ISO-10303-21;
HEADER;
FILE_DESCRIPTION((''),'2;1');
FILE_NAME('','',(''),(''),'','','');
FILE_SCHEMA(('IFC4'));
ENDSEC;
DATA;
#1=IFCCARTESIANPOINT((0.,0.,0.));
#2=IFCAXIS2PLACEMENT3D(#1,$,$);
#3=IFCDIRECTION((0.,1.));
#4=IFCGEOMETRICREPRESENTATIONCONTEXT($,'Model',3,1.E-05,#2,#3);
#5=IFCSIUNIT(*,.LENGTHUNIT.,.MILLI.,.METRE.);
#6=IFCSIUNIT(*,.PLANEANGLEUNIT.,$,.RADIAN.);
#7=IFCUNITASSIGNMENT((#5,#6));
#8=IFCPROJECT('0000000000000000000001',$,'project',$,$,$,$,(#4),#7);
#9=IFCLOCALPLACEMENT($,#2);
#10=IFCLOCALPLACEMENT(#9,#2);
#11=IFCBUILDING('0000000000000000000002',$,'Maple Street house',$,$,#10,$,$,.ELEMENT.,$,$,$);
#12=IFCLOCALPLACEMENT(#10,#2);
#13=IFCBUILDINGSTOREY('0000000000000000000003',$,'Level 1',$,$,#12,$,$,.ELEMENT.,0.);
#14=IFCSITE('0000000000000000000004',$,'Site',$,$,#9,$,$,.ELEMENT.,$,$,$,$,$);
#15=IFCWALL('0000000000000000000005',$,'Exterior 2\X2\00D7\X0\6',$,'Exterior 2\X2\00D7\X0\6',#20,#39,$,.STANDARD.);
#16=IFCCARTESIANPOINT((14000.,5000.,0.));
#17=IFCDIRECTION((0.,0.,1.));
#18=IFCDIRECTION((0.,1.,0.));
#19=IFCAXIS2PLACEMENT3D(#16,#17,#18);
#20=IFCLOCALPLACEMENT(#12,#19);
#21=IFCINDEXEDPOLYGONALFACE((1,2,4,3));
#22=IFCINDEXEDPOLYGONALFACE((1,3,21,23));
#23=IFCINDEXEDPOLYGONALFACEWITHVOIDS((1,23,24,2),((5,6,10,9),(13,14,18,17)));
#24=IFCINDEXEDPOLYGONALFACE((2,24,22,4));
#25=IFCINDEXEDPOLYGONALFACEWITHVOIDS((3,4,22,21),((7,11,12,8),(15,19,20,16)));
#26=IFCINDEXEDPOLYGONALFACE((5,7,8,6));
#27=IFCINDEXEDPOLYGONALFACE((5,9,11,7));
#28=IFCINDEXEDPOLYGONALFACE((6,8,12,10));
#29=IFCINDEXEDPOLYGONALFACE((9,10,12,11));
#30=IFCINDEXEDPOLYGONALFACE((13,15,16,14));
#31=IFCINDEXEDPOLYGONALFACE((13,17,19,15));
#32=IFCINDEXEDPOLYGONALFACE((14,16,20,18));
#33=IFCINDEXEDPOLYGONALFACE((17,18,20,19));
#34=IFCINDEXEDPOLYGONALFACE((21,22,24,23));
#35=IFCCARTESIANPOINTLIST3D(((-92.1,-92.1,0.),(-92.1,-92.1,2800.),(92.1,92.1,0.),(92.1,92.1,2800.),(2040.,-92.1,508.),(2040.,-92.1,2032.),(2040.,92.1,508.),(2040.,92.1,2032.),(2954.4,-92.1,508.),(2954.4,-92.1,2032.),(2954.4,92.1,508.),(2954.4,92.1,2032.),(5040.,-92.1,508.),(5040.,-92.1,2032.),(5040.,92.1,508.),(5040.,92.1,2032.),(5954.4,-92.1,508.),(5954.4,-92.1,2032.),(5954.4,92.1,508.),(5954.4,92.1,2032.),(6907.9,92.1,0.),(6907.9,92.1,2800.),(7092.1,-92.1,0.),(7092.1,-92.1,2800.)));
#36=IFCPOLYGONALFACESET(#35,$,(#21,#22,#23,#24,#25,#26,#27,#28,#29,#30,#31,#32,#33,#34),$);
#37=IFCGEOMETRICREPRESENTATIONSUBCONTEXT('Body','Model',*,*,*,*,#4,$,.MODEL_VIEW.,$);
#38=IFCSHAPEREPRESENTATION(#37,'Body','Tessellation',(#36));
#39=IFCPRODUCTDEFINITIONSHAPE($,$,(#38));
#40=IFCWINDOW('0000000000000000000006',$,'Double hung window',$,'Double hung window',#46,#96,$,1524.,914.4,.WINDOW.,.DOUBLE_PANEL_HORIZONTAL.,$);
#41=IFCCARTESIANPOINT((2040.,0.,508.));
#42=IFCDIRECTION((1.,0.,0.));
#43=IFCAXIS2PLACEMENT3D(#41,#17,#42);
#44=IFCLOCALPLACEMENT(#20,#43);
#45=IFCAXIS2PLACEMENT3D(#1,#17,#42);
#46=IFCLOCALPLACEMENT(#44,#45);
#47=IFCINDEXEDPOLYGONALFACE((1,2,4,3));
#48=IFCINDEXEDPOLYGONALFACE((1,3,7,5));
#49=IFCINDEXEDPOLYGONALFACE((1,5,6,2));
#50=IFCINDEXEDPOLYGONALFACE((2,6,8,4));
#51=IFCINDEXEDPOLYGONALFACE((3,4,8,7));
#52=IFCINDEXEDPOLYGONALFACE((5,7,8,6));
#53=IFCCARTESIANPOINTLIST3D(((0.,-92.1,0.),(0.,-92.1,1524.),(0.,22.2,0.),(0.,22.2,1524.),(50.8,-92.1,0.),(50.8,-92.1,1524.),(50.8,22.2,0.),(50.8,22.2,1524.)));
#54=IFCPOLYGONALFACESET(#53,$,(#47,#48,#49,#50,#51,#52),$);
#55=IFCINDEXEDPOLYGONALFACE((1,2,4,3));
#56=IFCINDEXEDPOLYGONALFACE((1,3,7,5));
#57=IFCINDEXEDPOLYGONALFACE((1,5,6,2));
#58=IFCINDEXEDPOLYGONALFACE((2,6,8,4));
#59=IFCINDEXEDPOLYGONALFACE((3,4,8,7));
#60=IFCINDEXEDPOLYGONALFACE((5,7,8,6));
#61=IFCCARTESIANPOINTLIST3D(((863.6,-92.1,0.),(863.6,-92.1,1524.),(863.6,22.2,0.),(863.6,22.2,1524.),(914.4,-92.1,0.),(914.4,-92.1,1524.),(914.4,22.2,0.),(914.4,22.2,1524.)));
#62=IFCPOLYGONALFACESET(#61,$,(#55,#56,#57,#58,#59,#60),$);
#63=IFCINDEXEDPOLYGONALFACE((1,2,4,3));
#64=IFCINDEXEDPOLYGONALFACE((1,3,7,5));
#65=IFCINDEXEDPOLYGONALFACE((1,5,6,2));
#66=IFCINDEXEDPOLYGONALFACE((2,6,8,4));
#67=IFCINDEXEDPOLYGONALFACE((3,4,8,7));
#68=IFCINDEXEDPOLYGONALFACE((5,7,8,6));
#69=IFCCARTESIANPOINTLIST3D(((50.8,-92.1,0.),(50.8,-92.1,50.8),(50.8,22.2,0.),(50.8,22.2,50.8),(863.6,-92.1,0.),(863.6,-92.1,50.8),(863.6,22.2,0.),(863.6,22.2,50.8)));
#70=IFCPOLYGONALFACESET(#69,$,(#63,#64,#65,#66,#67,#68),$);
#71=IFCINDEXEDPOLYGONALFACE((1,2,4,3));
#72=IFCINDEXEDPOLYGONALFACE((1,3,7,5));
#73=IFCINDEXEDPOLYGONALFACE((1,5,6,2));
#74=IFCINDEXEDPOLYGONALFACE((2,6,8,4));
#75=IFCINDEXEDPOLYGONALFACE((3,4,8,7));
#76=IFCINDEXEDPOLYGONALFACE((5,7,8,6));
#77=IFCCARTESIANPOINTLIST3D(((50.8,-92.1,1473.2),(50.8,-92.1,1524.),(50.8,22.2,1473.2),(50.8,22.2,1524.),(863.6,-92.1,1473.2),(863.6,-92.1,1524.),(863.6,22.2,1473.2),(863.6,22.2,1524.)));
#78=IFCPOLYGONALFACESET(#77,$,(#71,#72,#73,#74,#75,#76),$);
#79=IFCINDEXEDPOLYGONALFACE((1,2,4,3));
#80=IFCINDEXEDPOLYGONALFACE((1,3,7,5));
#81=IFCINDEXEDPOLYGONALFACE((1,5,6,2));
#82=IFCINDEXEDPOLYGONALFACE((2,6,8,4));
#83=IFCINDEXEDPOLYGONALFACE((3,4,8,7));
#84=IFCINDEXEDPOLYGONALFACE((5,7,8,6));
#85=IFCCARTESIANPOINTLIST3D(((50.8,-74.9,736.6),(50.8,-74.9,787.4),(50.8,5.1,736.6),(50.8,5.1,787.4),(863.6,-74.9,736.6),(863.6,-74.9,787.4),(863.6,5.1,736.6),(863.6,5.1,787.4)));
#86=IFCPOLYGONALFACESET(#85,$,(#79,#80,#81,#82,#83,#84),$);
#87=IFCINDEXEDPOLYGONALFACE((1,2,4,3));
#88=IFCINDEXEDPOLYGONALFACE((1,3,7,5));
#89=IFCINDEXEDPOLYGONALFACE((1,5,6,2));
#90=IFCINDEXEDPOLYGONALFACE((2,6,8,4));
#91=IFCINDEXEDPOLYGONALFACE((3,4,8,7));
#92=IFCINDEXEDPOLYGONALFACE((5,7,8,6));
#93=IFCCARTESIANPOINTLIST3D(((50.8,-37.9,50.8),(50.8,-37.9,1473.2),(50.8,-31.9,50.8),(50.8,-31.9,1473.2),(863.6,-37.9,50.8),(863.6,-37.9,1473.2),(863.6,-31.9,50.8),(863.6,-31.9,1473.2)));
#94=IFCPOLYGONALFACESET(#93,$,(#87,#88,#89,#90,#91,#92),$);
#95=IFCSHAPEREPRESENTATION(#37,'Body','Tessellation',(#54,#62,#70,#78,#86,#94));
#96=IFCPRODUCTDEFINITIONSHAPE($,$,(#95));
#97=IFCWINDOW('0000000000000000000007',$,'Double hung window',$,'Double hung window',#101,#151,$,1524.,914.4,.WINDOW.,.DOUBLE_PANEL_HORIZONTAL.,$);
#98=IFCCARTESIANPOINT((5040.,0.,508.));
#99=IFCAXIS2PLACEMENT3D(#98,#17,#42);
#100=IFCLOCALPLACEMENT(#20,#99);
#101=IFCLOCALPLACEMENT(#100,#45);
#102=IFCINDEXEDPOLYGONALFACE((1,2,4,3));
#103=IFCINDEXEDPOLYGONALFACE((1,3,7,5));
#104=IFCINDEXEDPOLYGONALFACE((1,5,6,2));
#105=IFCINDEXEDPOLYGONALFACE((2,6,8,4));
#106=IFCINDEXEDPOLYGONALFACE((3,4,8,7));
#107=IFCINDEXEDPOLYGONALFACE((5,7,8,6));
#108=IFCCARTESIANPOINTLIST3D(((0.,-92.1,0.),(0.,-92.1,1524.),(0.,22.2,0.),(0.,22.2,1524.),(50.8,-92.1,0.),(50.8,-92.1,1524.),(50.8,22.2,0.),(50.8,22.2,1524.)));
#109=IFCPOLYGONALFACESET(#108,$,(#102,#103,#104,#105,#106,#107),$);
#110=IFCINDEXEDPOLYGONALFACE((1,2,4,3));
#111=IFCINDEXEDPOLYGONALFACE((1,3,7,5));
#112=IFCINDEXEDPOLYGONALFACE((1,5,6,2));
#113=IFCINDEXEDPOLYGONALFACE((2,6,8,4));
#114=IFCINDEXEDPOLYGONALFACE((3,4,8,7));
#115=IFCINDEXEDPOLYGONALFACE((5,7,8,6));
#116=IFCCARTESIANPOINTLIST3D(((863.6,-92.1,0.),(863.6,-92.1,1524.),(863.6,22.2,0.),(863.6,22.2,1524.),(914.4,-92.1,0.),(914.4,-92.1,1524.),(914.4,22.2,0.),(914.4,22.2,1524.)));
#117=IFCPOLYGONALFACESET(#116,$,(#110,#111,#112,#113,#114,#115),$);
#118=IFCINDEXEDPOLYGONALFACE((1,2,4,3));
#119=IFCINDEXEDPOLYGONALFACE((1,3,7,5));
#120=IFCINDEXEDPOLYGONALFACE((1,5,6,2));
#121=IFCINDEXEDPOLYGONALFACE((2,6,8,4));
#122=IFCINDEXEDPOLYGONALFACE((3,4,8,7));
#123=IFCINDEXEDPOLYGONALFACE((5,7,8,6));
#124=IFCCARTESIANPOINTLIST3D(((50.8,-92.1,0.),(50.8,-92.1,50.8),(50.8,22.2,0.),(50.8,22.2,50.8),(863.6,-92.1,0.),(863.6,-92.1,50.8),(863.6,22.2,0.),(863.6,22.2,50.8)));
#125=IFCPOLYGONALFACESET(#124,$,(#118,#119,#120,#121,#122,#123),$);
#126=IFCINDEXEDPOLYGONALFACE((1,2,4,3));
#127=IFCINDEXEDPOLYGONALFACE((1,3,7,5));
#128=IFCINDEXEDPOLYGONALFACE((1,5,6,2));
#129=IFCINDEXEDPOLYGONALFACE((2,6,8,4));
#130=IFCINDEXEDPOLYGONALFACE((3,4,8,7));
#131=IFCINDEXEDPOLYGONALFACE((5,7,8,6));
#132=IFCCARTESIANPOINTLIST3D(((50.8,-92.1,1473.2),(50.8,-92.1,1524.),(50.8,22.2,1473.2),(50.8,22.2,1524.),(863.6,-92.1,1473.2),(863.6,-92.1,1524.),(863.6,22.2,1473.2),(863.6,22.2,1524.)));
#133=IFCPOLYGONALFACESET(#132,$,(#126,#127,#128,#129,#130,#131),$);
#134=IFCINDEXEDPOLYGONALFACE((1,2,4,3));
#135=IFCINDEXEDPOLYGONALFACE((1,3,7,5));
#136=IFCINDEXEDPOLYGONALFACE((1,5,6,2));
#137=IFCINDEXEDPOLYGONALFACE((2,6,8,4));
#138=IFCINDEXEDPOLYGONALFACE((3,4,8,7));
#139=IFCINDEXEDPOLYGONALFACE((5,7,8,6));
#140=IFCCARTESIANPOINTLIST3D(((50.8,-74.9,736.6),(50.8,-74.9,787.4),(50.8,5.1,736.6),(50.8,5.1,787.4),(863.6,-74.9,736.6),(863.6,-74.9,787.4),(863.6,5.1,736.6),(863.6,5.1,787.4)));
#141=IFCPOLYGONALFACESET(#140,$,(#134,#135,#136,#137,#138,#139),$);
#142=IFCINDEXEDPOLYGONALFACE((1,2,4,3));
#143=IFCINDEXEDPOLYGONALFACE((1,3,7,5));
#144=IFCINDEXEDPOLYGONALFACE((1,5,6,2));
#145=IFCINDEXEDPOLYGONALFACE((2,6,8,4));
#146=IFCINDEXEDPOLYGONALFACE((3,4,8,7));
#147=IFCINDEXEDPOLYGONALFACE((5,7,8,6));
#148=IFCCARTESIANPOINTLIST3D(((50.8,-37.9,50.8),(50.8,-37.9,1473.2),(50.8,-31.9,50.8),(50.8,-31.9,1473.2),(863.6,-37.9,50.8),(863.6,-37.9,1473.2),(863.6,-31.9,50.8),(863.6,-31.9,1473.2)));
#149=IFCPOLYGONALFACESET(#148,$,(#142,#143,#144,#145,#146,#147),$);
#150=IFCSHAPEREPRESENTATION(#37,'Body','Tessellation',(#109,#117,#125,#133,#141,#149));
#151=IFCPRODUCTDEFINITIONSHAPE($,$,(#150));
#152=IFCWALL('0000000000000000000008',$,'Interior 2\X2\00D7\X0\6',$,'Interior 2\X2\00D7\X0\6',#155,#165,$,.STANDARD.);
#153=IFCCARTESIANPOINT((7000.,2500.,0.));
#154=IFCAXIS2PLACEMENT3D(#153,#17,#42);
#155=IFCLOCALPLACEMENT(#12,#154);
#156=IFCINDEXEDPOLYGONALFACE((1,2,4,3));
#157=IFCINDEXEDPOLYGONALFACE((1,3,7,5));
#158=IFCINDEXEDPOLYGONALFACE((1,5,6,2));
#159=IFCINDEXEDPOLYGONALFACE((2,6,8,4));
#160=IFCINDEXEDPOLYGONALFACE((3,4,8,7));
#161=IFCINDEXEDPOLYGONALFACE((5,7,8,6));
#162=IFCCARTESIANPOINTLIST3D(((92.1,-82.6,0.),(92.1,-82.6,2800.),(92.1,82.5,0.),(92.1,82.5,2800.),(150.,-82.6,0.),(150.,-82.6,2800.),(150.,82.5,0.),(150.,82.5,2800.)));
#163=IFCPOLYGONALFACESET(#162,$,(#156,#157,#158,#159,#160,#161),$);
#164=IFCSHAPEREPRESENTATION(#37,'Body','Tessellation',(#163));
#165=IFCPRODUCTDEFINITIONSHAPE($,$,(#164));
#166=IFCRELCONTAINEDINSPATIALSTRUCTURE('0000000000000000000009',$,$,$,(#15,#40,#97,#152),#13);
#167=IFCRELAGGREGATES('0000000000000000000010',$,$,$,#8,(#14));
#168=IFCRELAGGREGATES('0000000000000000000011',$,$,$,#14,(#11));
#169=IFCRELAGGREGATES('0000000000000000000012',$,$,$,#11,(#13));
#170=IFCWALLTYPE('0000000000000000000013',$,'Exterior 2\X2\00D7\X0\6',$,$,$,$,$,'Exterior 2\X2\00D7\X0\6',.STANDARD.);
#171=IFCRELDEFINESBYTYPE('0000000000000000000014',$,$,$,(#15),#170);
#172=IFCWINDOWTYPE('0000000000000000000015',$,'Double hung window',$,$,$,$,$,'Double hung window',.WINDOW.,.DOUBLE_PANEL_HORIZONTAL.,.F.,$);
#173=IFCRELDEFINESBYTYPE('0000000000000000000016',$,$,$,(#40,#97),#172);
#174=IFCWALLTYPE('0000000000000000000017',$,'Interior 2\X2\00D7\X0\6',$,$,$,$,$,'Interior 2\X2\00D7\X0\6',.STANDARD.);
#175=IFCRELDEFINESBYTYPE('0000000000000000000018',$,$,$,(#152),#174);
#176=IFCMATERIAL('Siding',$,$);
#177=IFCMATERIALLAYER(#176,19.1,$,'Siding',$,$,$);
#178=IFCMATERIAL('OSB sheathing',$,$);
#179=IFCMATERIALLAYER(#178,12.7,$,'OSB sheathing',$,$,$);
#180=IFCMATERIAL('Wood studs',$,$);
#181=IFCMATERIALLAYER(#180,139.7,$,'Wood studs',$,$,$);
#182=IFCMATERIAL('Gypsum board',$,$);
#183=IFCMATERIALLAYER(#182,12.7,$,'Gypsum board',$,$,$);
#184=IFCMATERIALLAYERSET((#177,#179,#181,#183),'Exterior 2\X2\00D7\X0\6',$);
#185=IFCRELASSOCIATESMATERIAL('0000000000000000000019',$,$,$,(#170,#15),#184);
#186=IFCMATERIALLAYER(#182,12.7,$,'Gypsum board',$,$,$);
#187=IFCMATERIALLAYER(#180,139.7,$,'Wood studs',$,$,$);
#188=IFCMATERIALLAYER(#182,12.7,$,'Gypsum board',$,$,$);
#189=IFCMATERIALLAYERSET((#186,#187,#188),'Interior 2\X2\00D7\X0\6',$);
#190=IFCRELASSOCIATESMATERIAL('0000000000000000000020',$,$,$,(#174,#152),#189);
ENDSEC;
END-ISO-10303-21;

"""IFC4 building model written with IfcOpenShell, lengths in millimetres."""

from ifc_helpers import new_model, si_unit, direction, frame, origin, origin_with_axes, place, context, subcontext, project, spatial, polyline, outline, extrude, material, layer, layer_set, layer_usage, type_object, element, fill, save


model = new_model("IFC4")

# Units and contexts
model_context = context("Model", 3, precision=1e-05, world=origin(), true_north=direction((0.0, 1.0)))
body_context = subcontext(model_context, "Body", "Model", "MODEL_VIEW")
ifc_project = project(units=[si_unit("LENGTHUNIT", "METRE", prefix="MILLI"), si_unit("PLANEANGLEUNIT", "RADIAN")], contexts=[model_context])

# Site, building, storey
site_placement = place(None, origin())
site = spatial("IfcSite", under=ifc_project, at=site_placement, Name="Site", CompositionType="ELEMENT")
building_placement = place(site_placement, origin())
building = spatial("IfcBuilding", under=site, at=building_placement, Name="Maple Street house", CompositionType="ELEMENT")
storey_placement = place(building_placement, origin())
storey = spatial("IfcBuildingStorey", under=building, at=storey_placement, Name="Level 1", CompositionType="ELEMENT", Elevation=0.0)

# Wall, openings, windows
ifc_material_1 = material(Name="Siding")
ifc_layer_1 = layer(ifc_material_1, 19.1, Name="Siding")
ifc_material_2 = material(Name="OSB sheathing")
ifc_layer_2 = layer(ifc_material_2, 12.7, Name="OSB sheathing")
ifc_material_3 = material(Name="Wood studs")
ifc_layer_3 = layer(ifc_material_3, 139.7, Name="Wood studs")
ifc_material_4 = material(Name="Gypsum board")
ifc_layer_4 = layer(ifc_material_4, 12.7, Name="Gypsum board")
ifc_layer_set_1 = layer_set([ifc_layer_1, ifc_layer_2, ifc_layer_3, ifc_layer_4], Name="Exterior 2×6")
ifc_layer_usage_1 = layer_usage(ifc_layer_set_1, "AXIS2", "POSITIVE", -92.1)
wall_type_1 = type_object("IfcWallType", Name="Exterior 2×6", ElementType="Exterior 2×6", PredefinedType="STANDARD", material=ifc_layer_set_1)
wall_1_placement = place(storey_placement, frame((14000.0, 5000.0, 0.0), z_axis=(0.0, 0.0, 1.0), x_axis=(0.0, 1.0, 0.0)))
wall_1 = element("IfcWall", 1, at=wall_1_placement, inside=storey, type_object=wall_type_1, material=ifc_layer_usage_1, Name="Exterior 2×6", ObjectType="Exterior 2×6", PredefinedType="STANDARD", context=body_context, shape_type="SweptSolid", body=[
    extrude(outline(polyline([(-92.1, -92.1), (7092.1, -92.1), (6907.9, 92.1), (92.1, 92.1), (-92.1, -92.1)])), origin(), (0.0, 0.0, 1.0), 2800.0),
])
opening_1_placement = place(wall_1_placement, frame((2040.0, 0.0, 508.0), z_axis=(0.0, 0.0, 1.0), x_axis=(1.0, 0.0, 0.0)))
opening_1 = element("IfcOpeningElement", 2, at=opening_1_placement, cuts=wall_1, PredefinedType="OPENING", context=body_context, shape_type="SweptSolid", body=[
    extrude(outline(polyline([(0.0, -102.1), (914.4, -102.1), (914.4, 102.1), (0.0, 102.1), (0.0, -102.1)])), origin(), (0.0, 0.0, 1.0), 1524.0),
])
opening_2_placement = place(wall_1_placement, frame((5040.0, 0.0, 508.0), z_axis=(0.0, 0.0, 1.0), x_axis=(1.0, 0.0, 0.0)))
opening_2 = element("IfcOpeningElement", 3, at=opening_2_placement, cuts=wall_1, PredefinedType="OPENING", context=body_context, shape_type="SweptSolid", body=[
    extrude(outline(polyline([(0.0, -102.1), (914.4, -102.1), (914.4, 102.1), (0.0, 102.1), (0.0, -102.1)])), origin(), (0.0, 0.0, 1.0), 1524.0),
])
window_type = type_object("IfcWindowType", Name="Double hung window", ElementType="Double hung window", ParameterTakesPrecedence=False, PartitioningType="DOUBLE_PANEL_HORIZONTAL", PredefinedType="WINDOW")
window_1_placement = place(opening_1_placement, origin_with_axes())
window_1 = element("IfcWindow", 4, at=window_1_placement, inside=storey, type_object=window_type, Name="Double hung window", ObjectType="Double hung window", OverallHeight=1524.0, OverallWidth=914.4, PartitioningType="DOUBLE_PANEL_HORIZONTAL", PredefinedType="WINDOW", context=body_context, shape_type="SweptSolid", body=[
    extrude(outline(polyline([(0.0, -92.1), (50.8, -92.1), (50.8, 22.2), (0.0, 22.2), (0.0, -92.1)])), origin(), (0.0, 0.0, 1.0), 1524.0),
    extrude(outline(polyline([(863.6, -92.1), (914.4, -92.1), (914.4, 22.2), (863.6, 22.2), (863.6, -92.1)])), origin(), (0.0, 0.0, 1.0), 1524.0),
    extrude(outline(polyline([(50.8, -92.1), (863.6, -92.1), (863.6, 22.2), (50.8, 22.2), (50.8, -92.1)])), origin(), (0.0, 0.0, 1.0), 50.8),
    extrude(outline(polyline([(50.8, -92.1), (863.6, -92.1), (863.6, 22.2), (50.8, 22.2), (50.8, -92.1)])), frame((0.0, 0.0, 1473.2)), (0.0, 0.0, 1.0), 50.8),
    extrude(outline(polyline([(50.8, -74.9), (863.6, -74.9), (863.6, 5.1), (50.8, 5.1), (50.8, -74.9)])), frame((0.0, 0.0, 736.6)), (0.0, 0.0, 1.0), 50.8),
    extrude(outline(polyline([(50.8, -37.9), (863.6, -37.9), (863.6, -31.9), (50.8, -31.9), (50.8, -37.9)])), frame((0.0, 0.0, 50.8)), (0.0, 0.0, 1.0), 1422.4),
])
fill(opening_1, window_1)
window_2_placement = place(opening_2_placement, origin_with_axes())
window_2 = element("IfcWindow", 5, at=window_2_placement, inside=storey, type_object=window_type, Name="Double hung window", ObjectType="Double hung window", OverallHeight=1524.0, OverallWidth=914.4, PartitioningType="DOUBLE_PANEL_HORIZONTAL", PredefinedType="WINDOW", context=body_context, shape_type="SweptSolid", body=[
    extrude(outline(polyline([(0.0, -92.1), (50.8, -92.1), (50.8, 22.2), (0.0, 22.2), (0.0, -92.1)])), origin(), (0.0, 0.0, 1.0), 1524.0),
    extrude(outline(polyline([(863.6, -92.1), (914.4, -92.1), (914.4, 22.2), (863.6, 22.2), (863.6, -92.1)])), origin(), (0.0, 0.0, 1.0), 1524.0),
    extrude(outline(polyline([(50.8, -92.1), (863.6, -92.1), (863.6, 22.2), (50.8, 22.2), (50.8, -92.1)])), origin(), (0.0, 0.0, 1.0), 50.8),
    extrude(outline(polyline([(50.8, -92.1), (863.6, -92.1), (863.6, 22.2), (50.8, 22.2), (50.8, -92.1)])), frame((0.0, 0.0, 1473.2)), (0.0, 0.0, 1.0), 50.8),
    extrude(outline(polyline([(50.8, -74.9), (863.6, -74.9), (863.6, 5.1), (50.8, 5.1), (50.8, -74.9)])), frame((0.0, 0.0, 736.6)), (0.0, 0.0, 1.0), 50.8),
    extrude(outline(polyline([(50.8, -37.9), (863.6, -37.9), (863.6, -31.9), (50.8, -31.9), (50.8, -37.9)])), frame((0.0, 0.0, 50.8)), (0.0, 0.0, 1.0), 1422.4),
])
fill(opening_2, window_2)

# Wall
ifc_layer_5 = layer(ifc_material_4, 12.7, Name="Gypsum board")
ifc_layer_6 = layer(ifc_material_3, 139.7, Name="Wood studs")
ifc_layer_7 = layer(ifc_material_4, 12.7, Name="Gypsum board")
ifc_layer_set_2 = layer_set([ifc_layer_5, ifc_layer_6, ifc_layer_7], Name="Interior 2×6")
ifc_layer_usage_2 = layer_usage(ifc_layer_set_2, "AXIS2", "NEGATIVE", 82.5)
wall_type_2 = type_object("IfcWallType", Name="Interior 2×6", ElementType="Interior 2×6", PredefinedType="STANDARD", material=ifc_layer_set_2)
wall_2_placement = place(storey_placement, frame((7000.0, 2500.0, 0.0), z_axis=(0.0, 0.0, 1.0), x_axis=(1.0, 0.0, 0.0)))
element("IfcWall", 6, at=wall_2_placement, inside=storey, type_object=wall_type_2, material=ifc_layer_usage_2, Name="Interior 2×6", ObjectType="Interior 2×6", PredefinedType="STANDARD", context=body_context, shape_type="SweptSolid", body=[
    extrude(outline(polyline([(92.1, -82.5), (150.0, -82.5), (150.0, 82.5), (92.1, 82.5), (92.1, -82.5)])), origin(), (0.0, 0.0, 1.0), 2800.0),
])

save(model, "model.ifc")
